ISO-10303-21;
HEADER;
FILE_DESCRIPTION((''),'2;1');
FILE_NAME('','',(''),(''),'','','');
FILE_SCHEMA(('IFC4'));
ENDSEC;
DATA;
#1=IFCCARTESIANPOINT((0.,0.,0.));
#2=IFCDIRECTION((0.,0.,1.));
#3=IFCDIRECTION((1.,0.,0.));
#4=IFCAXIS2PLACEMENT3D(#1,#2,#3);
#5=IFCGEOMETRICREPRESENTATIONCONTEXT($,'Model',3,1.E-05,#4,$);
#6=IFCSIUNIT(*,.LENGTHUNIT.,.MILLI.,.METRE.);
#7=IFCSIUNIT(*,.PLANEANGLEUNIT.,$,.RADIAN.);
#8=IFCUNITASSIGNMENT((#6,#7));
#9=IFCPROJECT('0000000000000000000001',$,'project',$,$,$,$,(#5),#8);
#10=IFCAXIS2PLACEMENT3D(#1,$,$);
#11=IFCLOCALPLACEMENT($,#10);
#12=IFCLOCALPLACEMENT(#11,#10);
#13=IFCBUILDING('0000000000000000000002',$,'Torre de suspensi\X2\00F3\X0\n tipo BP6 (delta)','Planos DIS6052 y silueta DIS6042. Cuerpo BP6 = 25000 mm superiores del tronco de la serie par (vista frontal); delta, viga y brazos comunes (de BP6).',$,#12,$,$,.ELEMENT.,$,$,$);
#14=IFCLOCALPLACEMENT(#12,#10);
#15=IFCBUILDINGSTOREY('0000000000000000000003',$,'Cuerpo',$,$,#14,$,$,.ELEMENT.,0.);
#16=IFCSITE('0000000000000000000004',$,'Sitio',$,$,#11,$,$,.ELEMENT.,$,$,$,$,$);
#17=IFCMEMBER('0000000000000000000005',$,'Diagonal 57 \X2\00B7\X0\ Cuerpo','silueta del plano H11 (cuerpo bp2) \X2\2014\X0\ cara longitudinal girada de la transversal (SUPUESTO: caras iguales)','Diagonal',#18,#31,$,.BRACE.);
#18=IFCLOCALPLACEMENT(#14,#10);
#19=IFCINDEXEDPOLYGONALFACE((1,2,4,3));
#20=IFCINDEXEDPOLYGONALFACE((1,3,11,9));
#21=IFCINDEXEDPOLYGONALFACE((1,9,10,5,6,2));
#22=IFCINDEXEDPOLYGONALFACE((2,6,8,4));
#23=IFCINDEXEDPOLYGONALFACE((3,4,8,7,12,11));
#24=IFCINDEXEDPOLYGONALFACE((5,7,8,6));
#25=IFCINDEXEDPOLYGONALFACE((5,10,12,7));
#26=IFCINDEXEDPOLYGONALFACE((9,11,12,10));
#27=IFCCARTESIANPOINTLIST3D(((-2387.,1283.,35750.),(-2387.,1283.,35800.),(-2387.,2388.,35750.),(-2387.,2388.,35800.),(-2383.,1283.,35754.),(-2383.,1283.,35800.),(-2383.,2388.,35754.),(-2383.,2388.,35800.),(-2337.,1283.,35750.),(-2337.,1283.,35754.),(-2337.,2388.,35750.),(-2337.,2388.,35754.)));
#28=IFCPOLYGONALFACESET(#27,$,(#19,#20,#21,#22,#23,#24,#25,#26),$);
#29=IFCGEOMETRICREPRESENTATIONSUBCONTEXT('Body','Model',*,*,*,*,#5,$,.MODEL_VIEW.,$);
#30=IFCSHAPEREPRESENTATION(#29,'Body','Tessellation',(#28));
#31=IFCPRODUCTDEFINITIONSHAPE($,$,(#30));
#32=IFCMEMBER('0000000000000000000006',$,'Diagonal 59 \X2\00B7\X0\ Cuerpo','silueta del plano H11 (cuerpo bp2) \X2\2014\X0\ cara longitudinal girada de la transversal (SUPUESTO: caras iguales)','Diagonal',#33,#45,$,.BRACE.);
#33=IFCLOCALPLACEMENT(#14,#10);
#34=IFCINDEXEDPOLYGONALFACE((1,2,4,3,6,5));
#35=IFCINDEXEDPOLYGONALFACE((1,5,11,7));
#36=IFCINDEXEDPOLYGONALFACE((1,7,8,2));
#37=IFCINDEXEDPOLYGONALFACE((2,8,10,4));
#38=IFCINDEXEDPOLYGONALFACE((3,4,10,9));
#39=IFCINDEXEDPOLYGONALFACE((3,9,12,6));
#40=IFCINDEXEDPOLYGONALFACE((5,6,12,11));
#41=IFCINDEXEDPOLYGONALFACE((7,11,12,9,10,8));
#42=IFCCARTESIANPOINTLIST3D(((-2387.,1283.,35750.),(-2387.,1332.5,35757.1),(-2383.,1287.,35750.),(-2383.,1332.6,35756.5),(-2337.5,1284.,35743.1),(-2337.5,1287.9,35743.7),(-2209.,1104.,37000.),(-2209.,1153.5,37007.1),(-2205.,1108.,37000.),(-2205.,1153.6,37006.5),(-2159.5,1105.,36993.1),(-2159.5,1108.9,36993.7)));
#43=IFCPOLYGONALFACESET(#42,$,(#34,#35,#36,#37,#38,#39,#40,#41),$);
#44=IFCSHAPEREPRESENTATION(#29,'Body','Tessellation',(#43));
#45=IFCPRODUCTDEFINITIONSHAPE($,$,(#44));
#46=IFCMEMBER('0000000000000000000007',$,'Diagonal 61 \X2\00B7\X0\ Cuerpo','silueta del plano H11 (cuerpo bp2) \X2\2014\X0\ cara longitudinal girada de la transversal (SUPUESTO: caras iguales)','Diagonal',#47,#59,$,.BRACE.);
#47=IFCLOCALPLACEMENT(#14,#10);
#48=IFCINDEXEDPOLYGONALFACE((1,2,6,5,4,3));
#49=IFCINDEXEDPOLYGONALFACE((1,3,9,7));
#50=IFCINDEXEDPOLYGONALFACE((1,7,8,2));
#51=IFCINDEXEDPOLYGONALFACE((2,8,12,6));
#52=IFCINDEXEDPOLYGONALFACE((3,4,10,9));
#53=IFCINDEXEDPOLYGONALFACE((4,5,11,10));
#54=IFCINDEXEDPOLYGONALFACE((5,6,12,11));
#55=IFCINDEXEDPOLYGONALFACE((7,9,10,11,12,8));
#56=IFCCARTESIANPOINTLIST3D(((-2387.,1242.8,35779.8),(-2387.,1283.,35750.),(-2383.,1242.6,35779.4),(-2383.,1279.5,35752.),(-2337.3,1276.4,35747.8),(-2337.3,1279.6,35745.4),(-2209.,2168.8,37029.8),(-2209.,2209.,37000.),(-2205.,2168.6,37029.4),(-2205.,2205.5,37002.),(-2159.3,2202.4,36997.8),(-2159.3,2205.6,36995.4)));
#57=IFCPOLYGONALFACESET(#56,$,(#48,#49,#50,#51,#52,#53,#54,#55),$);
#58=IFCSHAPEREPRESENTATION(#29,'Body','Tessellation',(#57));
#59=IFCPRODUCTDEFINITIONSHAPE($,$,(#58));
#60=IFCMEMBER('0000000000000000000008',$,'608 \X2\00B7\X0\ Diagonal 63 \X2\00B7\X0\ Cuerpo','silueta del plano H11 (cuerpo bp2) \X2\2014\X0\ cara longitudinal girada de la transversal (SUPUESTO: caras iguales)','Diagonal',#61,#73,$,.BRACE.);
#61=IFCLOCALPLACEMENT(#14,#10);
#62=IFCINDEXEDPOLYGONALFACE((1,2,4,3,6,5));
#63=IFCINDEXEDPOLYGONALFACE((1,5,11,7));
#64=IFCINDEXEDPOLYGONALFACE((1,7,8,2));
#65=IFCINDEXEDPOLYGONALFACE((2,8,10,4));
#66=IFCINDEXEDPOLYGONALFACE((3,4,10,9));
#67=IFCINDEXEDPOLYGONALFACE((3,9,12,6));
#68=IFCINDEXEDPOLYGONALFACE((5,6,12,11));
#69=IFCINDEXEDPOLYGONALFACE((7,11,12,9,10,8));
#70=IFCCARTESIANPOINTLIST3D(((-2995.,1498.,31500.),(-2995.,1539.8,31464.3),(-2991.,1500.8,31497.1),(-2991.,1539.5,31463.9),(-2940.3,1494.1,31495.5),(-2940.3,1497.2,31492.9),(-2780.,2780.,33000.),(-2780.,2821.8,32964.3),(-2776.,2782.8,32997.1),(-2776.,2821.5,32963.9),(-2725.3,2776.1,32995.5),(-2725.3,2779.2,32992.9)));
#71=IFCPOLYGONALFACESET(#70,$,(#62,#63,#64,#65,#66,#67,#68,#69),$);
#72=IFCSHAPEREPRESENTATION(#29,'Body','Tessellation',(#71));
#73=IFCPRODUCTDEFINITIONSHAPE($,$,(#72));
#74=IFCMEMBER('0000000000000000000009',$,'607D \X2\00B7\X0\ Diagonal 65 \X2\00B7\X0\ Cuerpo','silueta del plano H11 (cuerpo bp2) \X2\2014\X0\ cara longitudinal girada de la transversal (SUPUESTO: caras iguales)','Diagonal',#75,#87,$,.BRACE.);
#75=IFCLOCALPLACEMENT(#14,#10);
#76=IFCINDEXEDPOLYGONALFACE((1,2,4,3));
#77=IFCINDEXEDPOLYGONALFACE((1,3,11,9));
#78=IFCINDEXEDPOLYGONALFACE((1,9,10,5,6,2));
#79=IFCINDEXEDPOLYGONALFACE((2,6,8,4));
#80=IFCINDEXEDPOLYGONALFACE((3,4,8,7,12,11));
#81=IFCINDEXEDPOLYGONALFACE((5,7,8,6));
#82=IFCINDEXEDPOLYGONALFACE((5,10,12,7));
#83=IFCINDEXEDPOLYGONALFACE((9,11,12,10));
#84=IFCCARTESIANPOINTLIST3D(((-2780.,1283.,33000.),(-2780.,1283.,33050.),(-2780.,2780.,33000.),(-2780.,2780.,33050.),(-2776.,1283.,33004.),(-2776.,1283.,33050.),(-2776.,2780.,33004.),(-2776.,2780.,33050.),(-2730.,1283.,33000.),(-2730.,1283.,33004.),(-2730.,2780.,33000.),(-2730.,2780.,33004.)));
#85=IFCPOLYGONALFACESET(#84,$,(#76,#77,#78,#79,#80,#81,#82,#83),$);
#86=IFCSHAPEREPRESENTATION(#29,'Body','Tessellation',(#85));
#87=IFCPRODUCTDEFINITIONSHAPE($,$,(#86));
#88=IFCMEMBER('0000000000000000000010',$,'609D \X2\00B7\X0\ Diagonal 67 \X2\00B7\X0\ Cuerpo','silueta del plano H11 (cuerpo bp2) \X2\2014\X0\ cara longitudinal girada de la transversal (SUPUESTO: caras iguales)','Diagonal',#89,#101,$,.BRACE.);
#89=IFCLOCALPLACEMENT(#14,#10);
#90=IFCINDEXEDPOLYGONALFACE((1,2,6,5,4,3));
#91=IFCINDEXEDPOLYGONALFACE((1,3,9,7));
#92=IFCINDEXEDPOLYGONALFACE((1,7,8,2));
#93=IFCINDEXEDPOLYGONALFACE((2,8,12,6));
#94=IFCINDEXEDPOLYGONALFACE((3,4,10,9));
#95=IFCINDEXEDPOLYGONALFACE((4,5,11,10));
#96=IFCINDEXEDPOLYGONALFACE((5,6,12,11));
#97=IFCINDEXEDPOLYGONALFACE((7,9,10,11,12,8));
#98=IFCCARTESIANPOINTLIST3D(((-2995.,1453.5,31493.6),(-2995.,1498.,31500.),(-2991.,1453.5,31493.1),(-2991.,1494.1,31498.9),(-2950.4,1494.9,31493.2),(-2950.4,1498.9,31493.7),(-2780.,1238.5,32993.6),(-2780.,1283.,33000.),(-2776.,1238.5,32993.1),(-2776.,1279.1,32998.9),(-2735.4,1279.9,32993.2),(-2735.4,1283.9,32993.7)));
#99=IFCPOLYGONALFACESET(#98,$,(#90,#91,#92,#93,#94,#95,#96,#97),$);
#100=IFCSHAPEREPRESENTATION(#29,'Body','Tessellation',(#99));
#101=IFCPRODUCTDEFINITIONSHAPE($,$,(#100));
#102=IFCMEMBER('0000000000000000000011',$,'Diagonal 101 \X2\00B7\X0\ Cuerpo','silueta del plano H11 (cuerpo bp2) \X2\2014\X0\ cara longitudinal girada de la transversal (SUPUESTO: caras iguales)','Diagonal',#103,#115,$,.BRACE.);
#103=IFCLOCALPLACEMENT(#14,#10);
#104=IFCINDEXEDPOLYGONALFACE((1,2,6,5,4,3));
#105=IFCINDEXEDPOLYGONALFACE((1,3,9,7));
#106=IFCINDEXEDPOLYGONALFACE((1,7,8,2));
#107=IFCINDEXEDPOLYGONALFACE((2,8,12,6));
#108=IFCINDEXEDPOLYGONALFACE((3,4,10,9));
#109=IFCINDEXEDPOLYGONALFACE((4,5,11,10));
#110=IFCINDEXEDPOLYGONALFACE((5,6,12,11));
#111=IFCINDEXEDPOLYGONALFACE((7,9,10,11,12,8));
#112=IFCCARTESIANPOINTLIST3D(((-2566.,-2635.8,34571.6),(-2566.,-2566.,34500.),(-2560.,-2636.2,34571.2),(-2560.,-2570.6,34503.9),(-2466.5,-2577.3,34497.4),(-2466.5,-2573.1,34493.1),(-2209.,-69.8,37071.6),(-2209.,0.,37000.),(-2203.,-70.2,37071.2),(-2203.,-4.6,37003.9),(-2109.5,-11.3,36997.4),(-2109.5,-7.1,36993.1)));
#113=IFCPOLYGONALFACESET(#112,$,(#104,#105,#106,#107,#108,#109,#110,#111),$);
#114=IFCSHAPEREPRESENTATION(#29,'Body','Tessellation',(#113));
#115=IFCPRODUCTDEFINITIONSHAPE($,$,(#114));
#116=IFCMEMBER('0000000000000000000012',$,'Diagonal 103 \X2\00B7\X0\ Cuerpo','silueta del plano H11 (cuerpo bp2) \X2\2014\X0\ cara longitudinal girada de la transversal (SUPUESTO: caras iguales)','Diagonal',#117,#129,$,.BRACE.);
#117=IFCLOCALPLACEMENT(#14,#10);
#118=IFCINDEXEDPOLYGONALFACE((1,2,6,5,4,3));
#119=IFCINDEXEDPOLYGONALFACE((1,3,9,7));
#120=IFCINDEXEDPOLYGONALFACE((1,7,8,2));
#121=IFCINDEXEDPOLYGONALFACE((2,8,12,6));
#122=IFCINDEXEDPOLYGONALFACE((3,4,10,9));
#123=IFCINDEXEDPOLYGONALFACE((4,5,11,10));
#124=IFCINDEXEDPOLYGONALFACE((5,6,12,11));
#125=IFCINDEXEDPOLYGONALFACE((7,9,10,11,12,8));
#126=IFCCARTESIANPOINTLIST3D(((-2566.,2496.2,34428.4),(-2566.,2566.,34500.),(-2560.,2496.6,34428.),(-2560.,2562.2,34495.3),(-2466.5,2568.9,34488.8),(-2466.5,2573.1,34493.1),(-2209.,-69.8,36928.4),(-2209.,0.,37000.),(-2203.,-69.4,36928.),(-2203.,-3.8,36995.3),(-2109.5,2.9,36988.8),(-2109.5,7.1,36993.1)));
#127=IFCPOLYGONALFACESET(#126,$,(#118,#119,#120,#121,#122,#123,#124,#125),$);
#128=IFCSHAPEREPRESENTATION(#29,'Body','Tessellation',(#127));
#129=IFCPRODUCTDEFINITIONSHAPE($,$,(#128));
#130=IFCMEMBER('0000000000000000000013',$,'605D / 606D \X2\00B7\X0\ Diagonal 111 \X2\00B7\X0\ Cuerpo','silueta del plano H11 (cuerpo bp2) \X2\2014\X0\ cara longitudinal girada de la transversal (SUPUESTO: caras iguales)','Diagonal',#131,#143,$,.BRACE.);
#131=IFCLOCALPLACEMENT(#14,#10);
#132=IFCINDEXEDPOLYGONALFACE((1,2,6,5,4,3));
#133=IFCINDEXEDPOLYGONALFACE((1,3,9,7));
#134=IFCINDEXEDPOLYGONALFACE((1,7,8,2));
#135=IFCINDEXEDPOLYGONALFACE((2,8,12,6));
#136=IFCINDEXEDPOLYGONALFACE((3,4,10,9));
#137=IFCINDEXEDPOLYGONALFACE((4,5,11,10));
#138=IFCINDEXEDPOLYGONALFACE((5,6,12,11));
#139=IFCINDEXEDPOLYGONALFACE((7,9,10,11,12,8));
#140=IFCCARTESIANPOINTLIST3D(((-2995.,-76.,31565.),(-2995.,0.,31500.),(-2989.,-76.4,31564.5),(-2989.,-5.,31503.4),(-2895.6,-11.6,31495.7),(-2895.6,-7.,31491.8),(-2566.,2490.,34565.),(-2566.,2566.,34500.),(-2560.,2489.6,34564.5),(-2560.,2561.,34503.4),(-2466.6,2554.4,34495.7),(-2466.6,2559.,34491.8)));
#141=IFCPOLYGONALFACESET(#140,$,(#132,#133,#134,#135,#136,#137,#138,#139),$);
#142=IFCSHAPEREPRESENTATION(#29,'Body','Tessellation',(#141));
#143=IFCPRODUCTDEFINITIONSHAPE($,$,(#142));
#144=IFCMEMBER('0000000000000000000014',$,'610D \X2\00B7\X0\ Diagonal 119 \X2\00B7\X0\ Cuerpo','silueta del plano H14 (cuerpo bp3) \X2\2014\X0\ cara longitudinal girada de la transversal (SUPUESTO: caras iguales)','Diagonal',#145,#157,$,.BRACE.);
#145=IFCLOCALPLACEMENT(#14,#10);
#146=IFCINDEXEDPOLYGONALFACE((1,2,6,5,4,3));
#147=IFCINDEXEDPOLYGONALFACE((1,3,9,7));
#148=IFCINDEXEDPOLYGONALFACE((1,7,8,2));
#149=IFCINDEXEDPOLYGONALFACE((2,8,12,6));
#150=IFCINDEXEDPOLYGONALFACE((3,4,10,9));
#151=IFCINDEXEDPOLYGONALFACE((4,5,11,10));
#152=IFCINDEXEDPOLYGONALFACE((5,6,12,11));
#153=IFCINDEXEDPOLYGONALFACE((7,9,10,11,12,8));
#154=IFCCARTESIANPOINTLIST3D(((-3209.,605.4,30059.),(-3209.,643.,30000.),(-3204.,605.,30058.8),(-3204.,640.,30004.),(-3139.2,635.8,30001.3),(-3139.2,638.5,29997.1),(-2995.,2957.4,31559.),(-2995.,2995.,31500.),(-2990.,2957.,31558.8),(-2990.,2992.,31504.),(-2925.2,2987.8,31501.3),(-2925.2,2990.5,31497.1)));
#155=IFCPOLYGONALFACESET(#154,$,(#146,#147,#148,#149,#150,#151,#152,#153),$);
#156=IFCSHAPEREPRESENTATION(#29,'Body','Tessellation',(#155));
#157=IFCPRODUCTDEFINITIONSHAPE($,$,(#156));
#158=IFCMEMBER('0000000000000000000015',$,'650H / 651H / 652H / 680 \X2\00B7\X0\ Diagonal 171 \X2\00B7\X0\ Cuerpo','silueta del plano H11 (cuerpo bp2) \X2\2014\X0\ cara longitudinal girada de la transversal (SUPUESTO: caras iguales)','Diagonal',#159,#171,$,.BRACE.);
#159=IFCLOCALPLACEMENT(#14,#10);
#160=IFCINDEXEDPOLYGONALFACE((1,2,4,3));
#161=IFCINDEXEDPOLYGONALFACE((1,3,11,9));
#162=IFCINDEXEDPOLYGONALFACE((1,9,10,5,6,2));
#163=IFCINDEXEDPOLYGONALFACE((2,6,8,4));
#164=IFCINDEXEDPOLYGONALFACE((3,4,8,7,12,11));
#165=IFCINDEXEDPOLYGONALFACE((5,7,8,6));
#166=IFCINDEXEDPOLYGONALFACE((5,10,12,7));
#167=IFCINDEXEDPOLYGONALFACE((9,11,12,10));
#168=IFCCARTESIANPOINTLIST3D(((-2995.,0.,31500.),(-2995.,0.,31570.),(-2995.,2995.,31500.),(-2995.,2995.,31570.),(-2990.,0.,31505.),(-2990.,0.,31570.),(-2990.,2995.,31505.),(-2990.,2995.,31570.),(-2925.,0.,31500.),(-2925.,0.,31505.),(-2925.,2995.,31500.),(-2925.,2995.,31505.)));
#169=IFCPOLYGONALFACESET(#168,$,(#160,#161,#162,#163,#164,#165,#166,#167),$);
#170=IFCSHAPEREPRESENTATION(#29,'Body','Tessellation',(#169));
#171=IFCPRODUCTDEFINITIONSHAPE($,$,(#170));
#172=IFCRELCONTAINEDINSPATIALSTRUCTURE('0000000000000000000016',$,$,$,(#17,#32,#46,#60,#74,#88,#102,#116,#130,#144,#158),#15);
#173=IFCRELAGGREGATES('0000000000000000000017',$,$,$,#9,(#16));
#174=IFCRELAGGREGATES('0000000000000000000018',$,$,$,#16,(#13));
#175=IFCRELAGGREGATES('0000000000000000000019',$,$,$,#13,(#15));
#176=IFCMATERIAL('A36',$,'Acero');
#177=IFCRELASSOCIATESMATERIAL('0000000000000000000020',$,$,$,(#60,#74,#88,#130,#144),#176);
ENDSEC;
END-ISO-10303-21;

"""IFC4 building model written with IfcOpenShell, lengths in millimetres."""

from ifc_helpers import new_model, si_unit, frame, frame_2d, origin, origin_with_axes, place, context, subcontext, project, spatial, l_section, extrude, material, element, save


model = new_model("IFC4")

# Units and contexts
model_context = context("Model", 3, precision=1e-05, world=origin_with_axes())
body_context = subcontext(model_context, "Body", "Model", "MODEL_VIEW")
ifc_project = project(units=[si_unit("LENGTHUNIT", "METRE", prefix="MILLI"), si_unit("PLANEANGLEUNIT", "RADIAN")], contexts=[model_context])

# Site, building, storey
site_placement = place(None, origin())
site = spatial("IfcSite", under=ifc_project, at=site_placement, Name="Sitio", CompositionType="ELEMENT")
building_placement = place(site_placement, origin())
building = spatial("IfcBuilding", under=site, at=building_placement, Name="Torre de suspensión tipo BP6 (delta)", Description="Planos DIS6052 y silueta DIS6042. Cuerpo BP6 = 25000 mm superiores del tronco de la serie par (vista frontal); delta, viga y brazos comunes (de BP6).", CompositionType="ELEMENT")
storey_placement = place(building_placement, origin())
storey = spatial("IfcBuildingStorey", under=building, at=storey_placement, Name="Cuerpo", CompositionType="ELEMENT", Elevation=0.0)

# Members
ifc_material_1 = material(Name="A36", Category="Acero")
member_1_placement = place(storey_placement, frame((-2387.0, 2388.0, 35750.0), z_axis=(0.0, -1.0, 0.0), x_axis=(1.0, 0.0, 0.0)))
element("IfcMember", 1, at=member_1_placement, inside=storey, Name="Diagonal 57 · Cuerpo", Description="silueta del plano H11 (cuerpo bp2) — cara longitudinal girada de la transversal (SUPUESTO: caras iguales)", ObjectType="Diagonal", PredefinedType="BRACE", context=body_context, shape_type="SweptSolid", body=[
    extrude(l_section(Depth=50.0, Width=50.0, Thickness=4.0, at=frame_2d((25.0, 25.0))), None, (0.0, 0.0, 1.0), 1105.0),
])
member_2_placement = place(storey_placement, frame((-2387.0, 1283.0, 35750.0), z_axis=(0.139582, -0.140366, 0.980211), x_axis=(0.990211, 0.019786, -0.138173)))
element("IfcMember", 2, at=member_2_placement, inside=storey, Name="Diagonal 59 · Cuerpo", Description="silueta del plano H11 (cuerpo bp2) — cara longitudinal girada de la transversal (SUPUESTO: caras iguales)", ObjectType="Diagonal", PredefinedType="BRACE", context=body_context, shape_type="SweptSolid", body=[
    extrude(l_section(Depth=50.0, Width=50.0, Thickness=4.0, at=frame_2d((25.0, 25.0))), None, (0.0, 0.0, 1.0), 1275.2),
])
member_3_placement = place(storey_placement, frame((-2209.0, 2209.0, 37000.0), z_axis=(-0.113682, -0.591399, -0.798325), x_axis=(0.993517, -0.06767, -0.091347)))
element("IfcMember", 3, at=member_3_placement, inside=storey, Name="Diagonal 61 · Cuerpo", Description="silueta del plano H11 (cuerpo bp2) — cara longitudinal girada de la transversal (SUPUESTO: caras iguales)", ObjectType="Diagonal", PredefinedType="BRACE", context=body_context, shape_type="SweptSolid", body=[
    extrude(l_section(Depth=50.0, Width=50.0, Thickness=4.0, at=frame_2d((25.0, 25.0))), None, (0.0, 0.0, 1.0), 1565.8),
])
member_4_placement = place(storey_placement, frame((-2995.0, 1498.0, 31500.0), z_axis=(0.108319, 0.645883, 0.755713), x_axis=(0.994116, -0.070375, -0.082342)))
element("IfcMember", 4, at=member_4_placement, inside=storey, material=ifc_material_1, Name="608 · Diagonal 63 · Cuerpo", Description="silueta del plano H11 (cuerpo bp2) — cara longitudinal girada de la transversal (SUPUESTO: caras iguales)", ObjectType="Diagonal", PredefinedType="BRACE", context=body_context, shape_type="SweptSolid", body=[
    extrude(l_section(Depth=55.0, Width=55.0, Thickness=4.0, at=frame_2d((27.5, 27.5))), None, (0.0, 0.0, 1.0), 1984.9),
])
member_5_placement = place(storey_placement, frame((-2780.0, 2780.0, 33000.0), z_axis=(0.0, -1.0, 0.0), x_axis=(1.0, 0.0, 0.0)))
element("IfcMember", 5, at=member_5_placement, inside=storey, material=ifc_material_1, Name="607D · Diagonal 65 · Cuerpo", Description="silueta del plano H11 (cuerpo bp2) — cara longitudinal girada de la transversal (SUPUESTO: caras iguales)", ObjectType="Diagonal", PredefinedType="BRACE", context=body_context, shape_type="SweptSolid", body=[
    extrude(l_section(Depth=50.0, Width=50.0, Thickness=4.0, at=frame_2d((25.0, 25.0))), None, (0.0, 0.0, 1.0), 1497.0),
])
member_6_placement = place(storey_placement, frame((-2780.0, 1283.0, 33000.0), z_axis=(-0.140476, 0.140476, -0.980068), x_axis=(0.990084, 0.019931, -0.139055)))
element("IfcMember", 6, at=member_6_placement, inside=storey, material=ifc_material_1, Name="609D · Diagonal 67 · Cuerpo", Description="silueta del plano H11 (cuerpo bp2) — cara longitudinal girada de la transversal (SUPUESTO: caras iguales)", ObjectType="Diagonal", PredefinedType="BRACE", context=body_context, shape_type="SweptSolid", body=[
    extrude(l_section(Depth=45.0, Width=45.0, Thickness=4.0, at=frame_2d((22.5, 22.5))), None, (0.0, 0.0, 1.0), 1530.5),
])
for number, where, z_axis, x_axis, name in (
    (7, (-2209.0, 0.0, 37000.0), (-0.09916, -0.712728, -0.694396), (0.995072, -0.071024, -0.069197), "Diagonal 101 · Cuerpo"),
    (8, (-2209.0, 0.0, 37000.0), (-0.09916, 0.712728, -0.694396), (0.995072, 0.071024, -0.069197), "Diagonal 103 · Cuerpo"),
):
    element("IfcMember", number, at=place(storey_placement, frame(where, z_axis=z_axis, x_axis=x_axis)), inside=storey, Name=name, Description="silueta del plano H11 (cuerpo bp2) — cara longitudinal girada de la transversal (SUPUESTO: caras iguales)", ObjectType="Diagonal", PredefinedType="BRACE", context=body_context, shape_type="SweptSolid", body=[
        extrude(l_section(Depth=100.0, Width=100.0, Thickness=6.0, at=frame_2d((50.0, 50.0))), None, (0.0, 0.0, 1.0), 3600.3),
    ])
member_7_placement = place(storey_placement, frame((-2566.0, 2566.0, 34500.0), z_axis=(-0.108035, -0.646194, -0.755488), x_axis=(0.994147, -0.070222, -0.082099)))
element("IfcMember", 9, at=member_7_placement, inside=storey, material=ifc_material_1, Name="605D / 606D · Diagonal 111 · Cuerpo", Description="silueta del plano H11 (cuerpo bp2) — cara longitudinal girada de la transversal (SUPUESTO: caras iguales)", ObjectType="Diagonal", PredefinedType="BRACE", context=body_context, shape_type="SweptSolid", body=[
    extrude(l_section(Depth=100.0, Width=100.0, Thickness=6.0, at=frame_2d((50.0, 50.0))), None, (0.0, 0.0, 1.0), 3970.9),
])
member_8_placement = place(storey_placement, frame((-2995.0, 2995.0, 31500.0), z_axis=(-0.076489, -0.84066, -0.536135), x_axis=(0.99707, -0.06449, -0.041129)))
element("IfcMember", 10, at=member_8_placement, inside=storey, material=ifc_material_1, Name="610D · Diagonal 119 · Cuerpo", Description="silueta del plano H14 (cuerpo bp3) — cara longitudinal girada de la transversal (SUPUESTO: caras iguales)", ObjectType="Diagonal", PredefinedType="BRACE", context=body_context, shape_type="SweptSolid", body=[
    extrude(l_section(Depth=70.0, Width=70.0, Thickness=5.0, at=frame_2d((35.0, 35.0))), None, (0.0, 0.0, 1.0), 2797.8),
])
member_9_placement = place(storey_placement, frame((-2995.0, 2995.0, 31500.0), z_axis=(0.0, -1.0, 0.0), x_axis=(1.0, 0.0, 0.0)))
element("IfcMember", 11, at=member_9_placement, inside=storey, Name="650H / 651H / 652H / 680 · Diagonal 171 · Cuerpo", Description="silueta del plano H11 (cuerpo bp2) — cara longitudinal girada de la transversal (SUPUESTO: caras iguales)", ObjectType="Diagonal", PredefinedType="BRACE", context=body_context, shape_type="SweptSolid", body=[
    extrude(l_section(Depth=70.0, Width=70.0, Thickness=5.0, at=frame_2d((35.0, 35.0))), None, (0.0, 0.0, 1.0), 2995.0),
])

save(model, "model.ifc")
